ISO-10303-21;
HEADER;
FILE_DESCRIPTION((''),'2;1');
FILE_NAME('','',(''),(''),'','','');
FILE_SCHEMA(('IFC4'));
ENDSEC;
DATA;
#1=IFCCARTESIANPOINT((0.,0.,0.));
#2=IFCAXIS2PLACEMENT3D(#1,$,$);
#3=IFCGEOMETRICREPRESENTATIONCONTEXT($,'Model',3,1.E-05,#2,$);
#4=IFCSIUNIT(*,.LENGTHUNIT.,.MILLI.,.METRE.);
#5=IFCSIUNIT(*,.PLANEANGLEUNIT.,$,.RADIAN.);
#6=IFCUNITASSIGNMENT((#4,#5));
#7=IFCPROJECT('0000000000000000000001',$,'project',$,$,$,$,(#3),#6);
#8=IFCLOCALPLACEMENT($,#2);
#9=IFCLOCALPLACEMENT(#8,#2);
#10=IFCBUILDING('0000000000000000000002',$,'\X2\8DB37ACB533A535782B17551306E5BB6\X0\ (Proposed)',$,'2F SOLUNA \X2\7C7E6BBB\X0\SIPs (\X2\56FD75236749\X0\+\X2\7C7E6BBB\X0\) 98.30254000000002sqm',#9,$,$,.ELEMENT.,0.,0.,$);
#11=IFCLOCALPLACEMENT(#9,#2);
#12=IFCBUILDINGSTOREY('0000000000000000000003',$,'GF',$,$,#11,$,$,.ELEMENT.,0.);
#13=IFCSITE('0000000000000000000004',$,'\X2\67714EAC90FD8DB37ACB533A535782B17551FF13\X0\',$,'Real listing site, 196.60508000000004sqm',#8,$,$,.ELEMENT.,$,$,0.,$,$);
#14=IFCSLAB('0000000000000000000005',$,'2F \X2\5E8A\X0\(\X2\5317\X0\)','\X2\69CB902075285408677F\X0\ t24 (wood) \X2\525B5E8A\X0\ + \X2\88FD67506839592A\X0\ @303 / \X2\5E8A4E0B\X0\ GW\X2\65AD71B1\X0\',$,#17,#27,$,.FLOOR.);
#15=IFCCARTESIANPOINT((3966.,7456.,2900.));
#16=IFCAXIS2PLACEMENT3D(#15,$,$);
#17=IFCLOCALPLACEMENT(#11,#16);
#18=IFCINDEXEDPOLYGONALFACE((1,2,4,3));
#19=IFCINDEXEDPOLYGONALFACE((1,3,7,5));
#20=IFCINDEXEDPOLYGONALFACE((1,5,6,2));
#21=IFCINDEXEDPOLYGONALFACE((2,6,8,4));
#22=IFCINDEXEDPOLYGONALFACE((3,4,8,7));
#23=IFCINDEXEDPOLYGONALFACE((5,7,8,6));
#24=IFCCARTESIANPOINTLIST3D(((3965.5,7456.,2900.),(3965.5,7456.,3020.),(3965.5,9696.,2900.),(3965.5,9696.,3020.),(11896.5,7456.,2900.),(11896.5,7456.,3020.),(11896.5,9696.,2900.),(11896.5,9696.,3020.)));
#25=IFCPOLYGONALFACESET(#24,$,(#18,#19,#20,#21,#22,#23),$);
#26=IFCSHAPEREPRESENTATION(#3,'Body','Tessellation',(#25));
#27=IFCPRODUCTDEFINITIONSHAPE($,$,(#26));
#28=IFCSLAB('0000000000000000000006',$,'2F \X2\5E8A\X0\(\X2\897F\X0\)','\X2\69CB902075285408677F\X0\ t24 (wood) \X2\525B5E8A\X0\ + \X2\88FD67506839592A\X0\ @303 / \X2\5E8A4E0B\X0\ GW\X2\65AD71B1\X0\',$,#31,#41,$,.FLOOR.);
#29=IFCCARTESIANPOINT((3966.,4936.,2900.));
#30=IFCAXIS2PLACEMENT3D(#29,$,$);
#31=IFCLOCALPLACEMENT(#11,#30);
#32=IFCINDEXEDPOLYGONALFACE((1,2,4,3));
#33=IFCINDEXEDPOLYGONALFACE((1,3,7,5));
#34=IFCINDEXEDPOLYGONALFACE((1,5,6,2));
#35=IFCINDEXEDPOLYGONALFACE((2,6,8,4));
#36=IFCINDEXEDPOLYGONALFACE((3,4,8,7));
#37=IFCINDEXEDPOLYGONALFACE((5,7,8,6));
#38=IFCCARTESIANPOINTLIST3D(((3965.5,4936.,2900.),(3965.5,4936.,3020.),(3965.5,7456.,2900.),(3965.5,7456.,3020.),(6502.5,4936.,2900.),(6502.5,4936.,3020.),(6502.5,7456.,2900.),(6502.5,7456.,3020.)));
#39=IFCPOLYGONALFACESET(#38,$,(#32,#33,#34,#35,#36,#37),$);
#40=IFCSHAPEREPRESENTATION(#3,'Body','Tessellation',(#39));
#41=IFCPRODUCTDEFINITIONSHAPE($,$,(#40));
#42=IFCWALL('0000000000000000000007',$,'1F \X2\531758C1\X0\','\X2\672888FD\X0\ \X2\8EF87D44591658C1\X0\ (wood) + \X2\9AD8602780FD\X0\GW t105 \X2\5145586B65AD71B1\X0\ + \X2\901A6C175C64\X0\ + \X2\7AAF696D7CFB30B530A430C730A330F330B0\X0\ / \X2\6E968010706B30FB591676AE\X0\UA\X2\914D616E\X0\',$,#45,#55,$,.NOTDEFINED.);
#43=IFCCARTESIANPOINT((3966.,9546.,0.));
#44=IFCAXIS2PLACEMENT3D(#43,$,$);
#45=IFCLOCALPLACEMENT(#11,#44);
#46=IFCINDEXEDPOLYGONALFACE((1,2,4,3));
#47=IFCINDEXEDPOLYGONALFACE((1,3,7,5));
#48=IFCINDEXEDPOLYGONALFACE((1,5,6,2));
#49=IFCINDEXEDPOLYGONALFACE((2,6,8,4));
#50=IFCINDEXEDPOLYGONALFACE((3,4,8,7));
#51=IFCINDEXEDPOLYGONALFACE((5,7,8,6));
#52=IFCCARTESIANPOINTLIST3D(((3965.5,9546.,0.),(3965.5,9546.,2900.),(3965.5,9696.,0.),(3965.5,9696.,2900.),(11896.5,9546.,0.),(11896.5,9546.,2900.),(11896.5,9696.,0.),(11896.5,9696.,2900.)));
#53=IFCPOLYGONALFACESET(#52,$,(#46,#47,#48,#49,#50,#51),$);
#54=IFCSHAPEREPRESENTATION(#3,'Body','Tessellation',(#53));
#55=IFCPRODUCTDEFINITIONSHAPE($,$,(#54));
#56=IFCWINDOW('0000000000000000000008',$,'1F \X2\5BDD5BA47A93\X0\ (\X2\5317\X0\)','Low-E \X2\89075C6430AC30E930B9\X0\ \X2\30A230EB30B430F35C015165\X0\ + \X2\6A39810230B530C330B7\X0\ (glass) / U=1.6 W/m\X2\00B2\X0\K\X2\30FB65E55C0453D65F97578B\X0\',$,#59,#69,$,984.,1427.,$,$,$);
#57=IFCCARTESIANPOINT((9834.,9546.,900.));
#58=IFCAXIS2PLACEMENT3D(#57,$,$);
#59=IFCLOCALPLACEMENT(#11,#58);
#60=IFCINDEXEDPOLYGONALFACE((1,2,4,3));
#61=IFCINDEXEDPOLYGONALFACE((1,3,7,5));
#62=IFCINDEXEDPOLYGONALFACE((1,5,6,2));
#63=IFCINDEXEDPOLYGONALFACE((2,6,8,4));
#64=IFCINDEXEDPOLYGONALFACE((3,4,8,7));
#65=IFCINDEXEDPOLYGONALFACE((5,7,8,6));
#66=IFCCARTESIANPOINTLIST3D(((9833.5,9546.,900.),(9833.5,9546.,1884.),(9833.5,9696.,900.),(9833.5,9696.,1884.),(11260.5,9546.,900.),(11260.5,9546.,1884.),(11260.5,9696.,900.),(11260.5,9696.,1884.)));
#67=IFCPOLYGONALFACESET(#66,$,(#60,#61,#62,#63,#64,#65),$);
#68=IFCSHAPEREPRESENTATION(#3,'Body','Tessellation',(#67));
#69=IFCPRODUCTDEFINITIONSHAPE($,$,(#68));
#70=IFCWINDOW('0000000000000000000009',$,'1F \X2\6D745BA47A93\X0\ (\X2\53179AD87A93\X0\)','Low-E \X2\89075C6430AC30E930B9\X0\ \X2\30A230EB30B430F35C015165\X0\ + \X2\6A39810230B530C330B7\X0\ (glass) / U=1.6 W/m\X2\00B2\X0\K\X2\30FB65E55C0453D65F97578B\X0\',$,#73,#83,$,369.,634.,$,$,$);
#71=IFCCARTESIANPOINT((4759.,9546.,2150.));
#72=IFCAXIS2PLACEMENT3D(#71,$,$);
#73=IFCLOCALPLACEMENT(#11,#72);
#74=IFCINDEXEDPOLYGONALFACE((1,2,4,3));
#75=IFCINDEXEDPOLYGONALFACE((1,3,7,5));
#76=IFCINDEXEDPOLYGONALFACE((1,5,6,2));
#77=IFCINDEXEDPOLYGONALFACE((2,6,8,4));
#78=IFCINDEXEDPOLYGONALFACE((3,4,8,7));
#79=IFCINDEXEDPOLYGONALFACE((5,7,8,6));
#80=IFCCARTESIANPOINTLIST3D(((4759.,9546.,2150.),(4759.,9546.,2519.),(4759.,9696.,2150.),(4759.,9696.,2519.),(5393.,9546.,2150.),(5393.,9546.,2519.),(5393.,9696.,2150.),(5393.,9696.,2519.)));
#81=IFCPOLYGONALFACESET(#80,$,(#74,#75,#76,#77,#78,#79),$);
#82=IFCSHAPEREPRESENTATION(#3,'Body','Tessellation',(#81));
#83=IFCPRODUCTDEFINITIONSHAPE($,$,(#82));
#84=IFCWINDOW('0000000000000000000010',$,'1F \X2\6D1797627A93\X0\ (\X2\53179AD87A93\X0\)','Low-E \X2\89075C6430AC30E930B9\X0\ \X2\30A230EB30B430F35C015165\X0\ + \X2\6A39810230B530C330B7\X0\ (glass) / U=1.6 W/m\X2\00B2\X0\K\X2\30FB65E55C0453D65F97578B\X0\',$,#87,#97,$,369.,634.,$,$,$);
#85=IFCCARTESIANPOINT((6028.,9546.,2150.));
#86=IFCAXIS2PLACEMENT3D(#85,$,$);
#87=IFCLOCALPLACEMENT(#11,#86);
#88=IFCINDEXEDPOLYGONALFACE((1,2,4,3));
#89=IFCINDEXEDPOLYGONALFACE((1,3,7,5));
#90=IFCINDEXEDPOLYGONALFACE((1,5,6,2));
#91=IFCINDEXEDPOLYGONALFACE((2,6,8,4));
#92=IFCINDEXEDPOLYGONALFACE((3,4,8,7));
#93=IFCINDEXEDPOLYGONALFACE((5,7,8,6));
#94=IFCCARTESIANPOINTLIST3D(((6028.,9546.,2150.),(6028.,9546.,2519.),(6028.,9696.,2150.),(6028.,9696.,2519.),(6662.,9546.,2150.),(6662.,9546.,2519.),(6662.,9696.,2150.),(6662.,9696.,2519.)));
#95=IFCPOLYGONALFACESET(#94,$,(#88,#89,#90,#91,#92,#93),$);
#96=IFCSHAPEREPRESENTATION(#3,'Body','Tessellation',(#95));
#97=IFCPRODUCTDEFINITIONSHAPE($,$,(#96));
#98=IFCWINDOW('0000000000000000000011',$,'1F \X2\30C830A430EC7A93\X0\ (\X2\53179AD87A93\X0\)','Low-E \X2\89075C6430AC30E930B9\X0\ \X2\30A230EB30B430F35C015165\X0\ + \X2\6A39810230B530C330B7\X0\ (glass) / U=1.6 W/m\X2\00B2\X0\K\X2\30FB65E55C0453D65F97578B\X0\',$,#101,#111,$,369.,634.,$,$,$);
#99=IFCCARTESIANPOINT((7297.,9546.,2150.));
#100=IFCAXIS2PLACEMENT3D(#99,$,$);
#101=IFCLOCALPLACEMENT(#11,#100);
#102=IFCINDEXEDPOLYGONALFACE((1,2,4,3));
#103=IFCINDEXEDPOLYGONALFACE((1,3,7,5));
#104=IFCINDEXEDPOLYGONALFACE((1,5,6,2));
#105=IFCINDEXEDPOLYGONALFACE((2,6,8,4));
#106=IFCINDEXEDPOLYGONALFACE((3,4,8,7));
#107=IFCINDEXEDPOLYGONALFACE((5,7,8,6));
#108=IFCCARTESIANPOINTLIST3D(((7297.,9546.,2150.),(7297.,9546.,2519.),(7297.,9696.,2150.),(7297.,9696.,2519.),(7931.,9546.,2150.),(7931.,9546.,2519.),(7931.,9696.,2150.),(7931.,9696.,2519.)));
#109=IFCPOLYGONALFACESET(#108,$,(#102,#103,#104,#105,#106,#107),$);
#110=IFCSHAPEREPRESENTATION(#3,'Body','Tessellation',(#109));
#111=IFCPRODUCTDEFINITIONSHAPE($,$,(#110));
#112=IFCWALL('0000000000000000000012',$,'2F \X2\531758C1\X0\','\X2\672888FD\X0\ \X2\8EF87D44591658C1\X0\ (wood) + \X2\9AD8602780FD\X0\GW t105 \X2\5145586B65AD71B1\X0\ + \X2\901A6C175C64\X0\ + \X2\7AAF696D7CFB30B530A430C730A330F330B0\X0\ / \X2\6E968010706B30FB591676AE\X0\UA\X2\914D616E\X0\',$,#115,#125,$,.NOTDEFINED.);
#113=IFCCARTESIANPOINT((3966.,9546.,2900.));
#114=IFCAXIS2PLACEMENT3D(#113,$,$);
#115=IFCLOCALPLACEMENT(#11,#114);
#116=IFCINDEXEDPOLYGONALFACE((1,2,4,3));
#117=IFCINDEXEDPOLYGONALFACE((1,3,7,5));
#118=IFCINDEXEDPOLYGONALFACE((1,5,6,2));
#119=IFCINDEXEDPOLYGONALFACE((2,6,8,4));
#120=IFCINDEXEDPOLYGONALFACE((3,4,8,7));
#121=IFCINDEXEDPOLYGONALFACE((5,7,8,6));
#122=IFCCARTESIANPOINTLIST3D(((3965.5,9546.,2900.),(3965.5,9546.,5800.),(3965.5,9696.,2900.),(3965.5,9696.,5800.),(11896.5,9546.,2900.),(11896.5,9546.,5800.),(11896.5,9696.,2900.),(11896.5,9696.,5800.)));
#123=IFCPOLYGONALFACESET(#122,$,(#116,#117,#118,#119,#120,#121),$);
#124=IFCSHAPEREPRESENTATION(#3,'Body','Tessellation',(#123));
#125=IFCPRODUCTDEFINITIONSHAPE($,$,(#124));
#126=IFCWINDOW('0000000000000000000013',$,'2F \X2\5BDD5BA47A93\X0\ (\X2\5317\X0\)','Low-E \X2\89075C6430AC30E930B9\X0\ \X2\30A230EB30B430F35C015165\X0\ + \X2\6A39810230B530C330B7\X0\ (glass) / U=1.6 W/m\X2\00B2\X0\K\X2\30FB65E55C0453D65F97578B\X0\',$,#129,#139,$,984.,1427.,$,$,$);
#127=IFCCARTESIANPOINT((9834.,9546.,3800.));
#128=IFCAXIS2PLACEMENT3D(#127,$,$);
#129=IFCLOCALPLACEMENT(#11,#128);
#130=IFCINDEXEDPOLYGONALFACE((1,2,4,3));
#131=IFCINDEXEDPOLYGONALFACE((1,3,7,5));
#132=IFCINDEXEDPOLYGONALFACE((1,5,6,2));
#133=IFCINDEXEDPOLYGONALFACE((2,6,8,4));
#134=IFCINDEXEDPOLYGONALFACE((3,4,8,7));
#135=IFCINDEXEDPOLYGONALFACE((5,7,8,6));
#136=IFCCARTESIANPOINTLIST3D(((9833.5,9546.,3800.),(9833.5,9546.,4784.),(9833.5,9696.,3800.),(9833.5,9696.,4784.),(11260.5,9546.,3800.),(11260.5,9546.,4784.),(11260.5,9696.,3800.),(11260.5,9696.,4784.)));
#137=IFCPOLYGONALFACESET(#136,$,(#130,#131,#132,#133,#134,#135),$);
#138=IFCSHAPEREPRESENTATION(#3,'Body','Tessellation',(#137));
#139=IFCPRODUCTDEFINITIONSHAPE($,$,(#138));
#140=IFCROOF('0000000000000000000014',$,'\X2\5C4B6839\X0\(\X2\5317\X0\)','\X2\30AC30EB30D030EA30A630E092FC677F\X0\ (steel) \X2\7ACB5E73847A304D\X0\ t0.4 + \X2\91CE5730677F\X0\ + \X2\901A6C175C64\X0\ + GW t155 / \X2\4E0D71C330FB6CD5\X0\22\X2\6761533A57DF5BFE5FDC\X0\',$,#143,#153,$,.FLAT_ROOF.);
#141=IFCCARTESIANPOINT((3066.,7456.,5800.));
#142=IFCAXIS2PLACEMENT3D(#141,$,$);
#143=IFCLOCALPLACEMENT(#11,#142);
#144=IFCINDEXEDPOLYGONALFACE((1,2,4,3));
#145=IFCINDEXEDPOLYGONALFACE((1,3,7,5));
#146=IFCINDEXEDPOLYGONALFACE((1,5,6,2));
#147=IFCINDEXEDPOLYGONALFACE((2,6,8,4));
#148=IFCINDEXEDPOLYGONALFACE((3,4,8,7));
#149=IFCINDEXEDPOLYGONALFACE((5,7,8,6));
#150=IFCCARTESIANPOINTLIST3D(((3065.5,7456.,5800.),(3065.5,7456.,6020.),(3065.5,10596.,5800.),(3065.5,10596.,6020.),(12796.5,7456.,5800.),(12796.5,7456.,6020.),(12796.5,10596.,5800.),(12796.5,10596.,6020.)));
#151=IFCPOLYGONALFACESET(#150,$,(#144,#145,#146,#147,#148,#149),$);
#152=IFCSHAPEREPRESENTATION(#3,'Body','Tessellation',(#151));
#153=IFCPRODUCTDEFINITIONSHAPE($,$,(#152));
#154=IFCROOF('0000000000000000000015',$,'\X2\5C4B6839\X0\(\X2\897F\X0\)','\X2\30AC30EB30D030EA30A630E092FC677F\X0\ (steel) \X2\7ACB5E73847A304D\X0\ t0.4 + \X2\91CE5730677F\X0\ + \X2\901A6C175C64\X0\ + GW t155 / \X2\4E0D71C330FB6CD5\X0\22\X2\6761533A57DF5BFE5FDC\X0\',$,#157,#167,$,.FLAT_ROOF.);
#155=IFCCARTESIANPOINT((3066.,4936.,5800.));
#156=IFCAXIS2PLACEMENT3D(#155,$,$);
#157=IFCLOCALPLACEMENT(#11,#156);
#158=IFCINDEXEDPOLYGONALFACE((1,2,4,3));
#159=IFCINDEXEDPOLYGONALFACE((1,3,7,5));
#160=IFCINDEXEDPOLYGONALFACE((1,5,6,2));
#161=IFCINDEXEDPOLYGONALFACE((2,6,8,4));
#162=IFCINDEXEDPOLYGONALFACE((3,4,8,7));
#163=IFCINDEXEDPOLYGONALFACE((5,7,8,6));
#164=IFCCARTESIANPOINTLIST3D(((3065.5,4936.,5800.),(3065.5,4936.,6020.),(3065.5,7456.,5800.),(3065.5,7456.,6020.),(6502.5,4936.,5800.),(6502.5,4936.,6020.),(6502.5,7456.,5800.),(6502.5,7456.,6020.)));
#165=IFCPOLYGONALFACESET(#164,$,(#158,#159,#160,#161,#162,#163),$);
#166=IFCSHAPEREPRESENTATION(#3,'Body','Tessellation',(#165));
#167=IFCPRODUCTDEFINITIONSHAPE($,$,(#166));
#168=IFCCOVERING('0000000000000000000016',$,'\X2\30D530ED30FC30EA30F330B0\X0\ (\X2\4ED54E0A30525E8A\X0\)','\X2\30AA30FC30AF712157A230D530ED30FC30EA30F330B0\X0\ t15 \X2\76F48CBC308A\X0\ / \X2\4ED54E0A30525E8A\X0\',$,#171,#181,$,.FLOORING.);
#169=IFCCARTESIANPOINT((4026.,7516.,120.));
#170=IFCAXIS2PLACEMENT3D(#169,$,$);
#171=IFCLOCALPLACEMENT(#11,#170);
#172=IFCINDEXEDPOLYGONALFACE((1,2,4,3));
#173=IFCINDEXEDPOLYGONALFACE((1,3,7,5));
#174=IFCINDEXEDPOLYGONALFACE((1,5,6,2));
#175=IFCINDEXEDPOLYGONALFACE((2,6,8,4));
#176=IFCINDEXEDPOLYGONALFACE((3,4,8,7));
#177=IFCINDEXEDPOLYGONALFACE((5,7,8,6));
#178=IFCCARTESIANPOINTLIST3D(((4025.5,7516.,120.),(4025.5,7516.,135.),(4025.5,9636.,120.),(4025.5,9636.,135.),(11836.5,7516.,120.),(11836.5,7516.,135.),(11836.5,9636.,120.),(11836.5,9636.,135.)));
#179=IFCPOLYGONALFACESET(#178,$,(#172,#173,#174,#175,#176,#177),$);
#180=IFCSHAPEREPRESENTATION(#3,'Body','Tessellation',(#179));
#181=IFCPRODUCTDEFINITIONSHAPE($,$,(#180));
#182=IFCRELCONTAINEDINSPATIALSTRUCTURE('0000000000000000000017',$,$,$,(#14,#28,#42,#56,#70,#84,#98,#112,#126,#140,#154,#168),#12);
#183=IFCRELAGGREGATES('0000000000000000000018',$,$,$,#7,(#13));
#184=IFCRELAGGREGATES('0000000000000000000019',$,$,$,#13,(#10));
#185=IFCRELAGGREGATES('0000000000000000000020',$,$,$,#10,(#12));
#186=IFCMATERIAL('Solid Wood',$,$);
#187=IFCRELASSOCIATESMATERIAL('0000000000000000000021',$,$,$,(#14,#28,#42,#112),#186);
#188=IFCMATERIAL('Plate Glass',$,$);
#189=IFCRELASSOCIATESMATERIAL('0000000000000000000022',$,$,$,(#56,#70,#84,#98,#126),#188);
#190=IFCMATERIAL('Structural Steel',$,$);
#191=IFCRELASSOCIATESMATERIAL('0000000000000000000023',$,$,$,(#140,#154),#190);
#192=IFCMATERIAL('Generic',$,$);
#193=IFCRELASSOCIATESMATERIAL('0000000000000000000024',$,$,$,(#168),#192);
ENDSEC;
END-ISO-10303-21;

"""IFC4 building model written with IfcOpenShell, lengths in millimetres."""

from ifc_helpers import new_model, si_unit, frame, frame_2d, origin, place, context, project, spatial, rectangle, extrude, material, element, fill, save


model = new_model("IFC4")

# Units and contexts
model_context = context("Model", 3, precision=1e-05, world=origin())
ifc_project = project(units=[si_unit("LENGTHUNIT", "METRE", prefix="MILLI"), si_unit("PLANEANGLEUNIT", "RADIAN")], contexts=[model_context])

# Site, building, storey
site_placement = place(None, origin())
site = spatial("IfcSite", under=ifc_project, at=site_placement, Name="東京都足立区南花畑３", ObjectType="Real listing site, 196.60508000000004sqm", CompositionType="ELEMENT", RefElevation=0.0)
building_placement = place(site_placement, origin())
building = spatial("IfcBuilding", under=site, at=building_placement, Name="足立区南花畑の家 (Proposed)", ObjectType="2F SOLUNA 籾殻SIPs (国産杉+籾殻) 98.30254000000002sqm", CompositionType="ELEMENT", ElevationOfRefHeight=0.0, ElevationOfTerrain=0.0)
storey_placement = place(building_placement, origin())
storey = spatial("IfcBuildingStorey", under=building, at=storey_placement, Name="GF", CompositionType="ELEMENT", Elevation=0.0)

# Slabs
ifc_material_1 = material(Name="Solid Wood")
slab_1_placement = place(storey_placement, frame((3966.0, 7456.0, 2900.0)))
element("IfcSlab", 1, at=slab_1_placement, inside=storey, material=ifc_material_1, Name="2F 床(北)", Description="構造用合板 t24 (wood) 剛床 + 製材根太 @303 / 床下 GW断熱", PredefinedType="FLOOR", context=model_context, shape_type="SweptSolid", body=[
    extrude(rectangle(XDim=7931.0, YDim=2240.0, at=frame_2d((3965.0, 1120.0))), frame((3966.0, 7456.0, 2900.0)), (0.0, 0.0, 1.0), 120.0),
])
slab_2_placement = place(storey_placement, frame((3966.0, 4936.0, 2900.0)))
element("IfcSlab", 2, at=slab_2_placement, inside=storey, material=ifc_material_1, Name="2F 床(西)", Description="構造用合板 t24 (wood) 剛床 + 製材根太 @303 / 床下 GW断熱", PredefinedType="FLOOR", context=model_context, shape_type="SweptSolid", body=[
    extrude(rectangle(XDim=2537.0, YDim=2520.0, at=frame_2d((1268.0, 1260.0))), frame((3966.0, 4936.0, 2900.0)), (0.0, 0.0, 1.0), 120.0),
])

# Wall, openings, windows
wall_1_placement = place(storey_placement, frame((3966.0, 9546.0, 0.0)))
wall_1 = element("IfcWall", 3, at=wall_1_placement, inside=storey, material=ifc_material_1, Name="1F 北壁", Description="木製 軸組外壁 (wood) + 高性能GW t105 充填断熱 + 通気層 + 窯業系サイディング / 準耐火・外皮UA配慮", PredefinedType="NOTDEFINED", context=model_context, shape_type="SweptSolid", body=[
    extrude(rectangle(XDim=7931.0, YDim=150.0, at=frame_2d((3965.0, 75.0))), frame((3966.0, 9546.0, 0.0)), (0.0, 0.0, 1.0), 2900.0),
])
opening_1_placement = place(storey_placement, frame((9834.0, 9546.0, 900.0)))
opening_1 = element("IfcOpeningElement", 4, at=opening_1_placement, cuts=wall_1, PredefinedType="NOTDEFINED", context=model_context, shape_type="SweptSolid", body=[
    extrude(rectangle(XDim=1427.0, YDim=150.0, at=frame_2d((713.0, 75.0))), frame((9834.0, 9546.0, 900.0)), (0.0, 0.0, 1.0), 984.0),
])
opening_2_placement = place(storey_placement, frame((4759.0, 9546.0, 2150.0)))
opening_2 = element("IfcOpeningElement", 5, at=opening_2_placement, cuts=wall_1, PredefinedType="NOTDEFINED", context=model_context, shape_type="SweptSolid", body=[
    extrude(rectangle(XDim=634.0, YDim=150.0, at=frame_2d((317.0, 75.0))), frame((4759.0, 9546.0, 2150.0)), (0.0, 0.0, 1.0), 369.0),
])
opening_3_placement = place(storey_placement, frame((6028.0, 9546.0, 2150.0)))
opening_3 = element("IfcOpeningElement", 6, at=opening_3_placement, cuts=wall_1, PredefinedType="NOTDEFINED", context=model_context, shape_type="SweptSolid", body=[
    extrude(rectangle(XDim=634.0, YDim=150.0, at=frame_2d((317.0, 75.0))), frame((6028.0, 9546.0, 2150.0)), (0.0, 0.0, 1.0), 369.0),
])
opening_4_placement = place(storey_placement, frame((7297.0, 9546.0, 2150.0)))
opening_4 = element("IfcOpeningElement", 7, at=opening_4_placement, cuts=wall_1, PredefinedType="NOTDEFINED", context=model_context, shape_type="SweptSolid", body=[
    extrude(rectangle(XDim=634.0, YDim=150.0, at=frame_2d((317.0, 75.0))), frame((7297.0, 9546.0, 2150.0)), (0.0, 0.0, 1.0), 369.0),
])
ifc_material_2 = material(Name="Plate Glass")
window_1_placement = place(storey_placement, frame((9834.0, 9546.0, 900.0)))
window_1 = element("IfcWindow", 8, at=window_1_placement, inside=storey, material=ifc_material_2, Name="1F 寝室窓 (北)", Description="Low-E 複層ガラス アルゴン封入 + 樹脂サッシ (glass) / U=1.6 W/m²K・日射取得型", OverallHeight=984.0, OverallWidth=1427.0, context=model_context, shape_type="SweptSolid", body=[
    extrude(rectangle(XDim=1427.0, YDim=150.0, at=frame_2d((713.0, 75.0))), frame((9834.0, 9546.0, 900.0)), (0.0, 0.0, 1.0), 984.0),
])
fill(opening_1, window_1)
window_2_placement = place(storey_placement, frame((4759.0, 9546.0, 2150.0)))
window_2 = element("IfcWindow", 9, at=window_2_placement, inside=storey, material=ifc_material_2, Name="1F 浴室窓 (北高窓)", Description="Low-E 複層ガラス アルゴン封入 + 樹脂サッシ (glass) / U=1.6 W/m²K・日射取得型", OverallHeight=369.0, OverallWidth=634.0, context=model_context, shape_type="SweptSolid", body=[
    extrude(rectangle(XDim=634.0, YDim=150.0, at=frame_2d((317.0, 75.0))), frame((4759.0, 9546.0, 2150.0)), (0.0, 0.0, 1.0), 369.0),
])
fill(opening_2, window_2)
window_3_placement = place(storey_placement, frame((6028.0, 9546.0, 2150.0)))
window_3 = element("IfcWindow", 10, at=window_3_placement, inside=storey, material=ifc_material_2, Name="1F 洗面窓 (北高窓)", Description="Low-E 複層ガラス アルゴン封入 + 樹脂サッシ (glass) / U=1.6 W/m²K・日射取得型", OverallHeight=369.0, OverallWidth=634.0, context=model_context, shape_type="SweptSolid", body=[
    extrude(rectangle(XDim=634.0, YDim=150.0, at=frame_2d((317.0, 75.0))), frame((6028.0, 9546.0, 2150.0)), (0.0, 0.0, 1.0), 369.0),
])
fill(opening_3, window_3)
window_4_placement = place(storey_placement, frame((7297.0, 9546.0, 2150.0)))
window_4 = element("IfcWindow", 11, at=window_4_placement, inside=storey, material=ifc_material_2, Name="1F トイレ窓 (北高窓)", Description="Low-E 複層ガラス アルゴン封入 + 樹脂サッシ (glass) / U=1.6 W/m²K・日射取得型", OverallHeight=369.0, OverallWidth=634.0, context=model_context, shape_type="SweptSolid", body=[
    extrude(rectangle(XDim=634.0, YDim=150.0, at=frame_2d((317.0, 75.0))), frame((7297.0, 9546.0, 2150.0)), (0.0, 0.0, 1.0), 369.0),
])
fill(opening_4, window_4)

# Wall, opening, window
wall_2_placement = place(storey_placement, frame((3966.0, 9546.0, 2900.0)))
wall_2 = element("IfcWall", 12, at=wall_2_placement, inside=storey, material=ifc_material_1, Name="2F 北壁", Description="木製 軸組外壁 (wood) + 高性能GW t105 充填断熱 + 通気層 + 窯業系サイディング / 準耐火・外皮UA配慮", PredefinedType="NOTDEFINED", context=model_context, shape_type="SweptSolid", body=[
    extrude(rectangle(XDim=7931.0, YDim=150.0, at=frame_2d((3965.0, 75.0))), frame((3966.0, 9546.0, 2900.0)), (0.0, 0.0, 1.0), 2900.0),
])
opening_5_placement = place(storey_placement, frame((9834.0, 9546.0, 3800.0)))
opening_5 = element("IfcOpeningElement", 13, at=opening_5_placement, cuts=wall_2, PredefinedType="NOTDEFINED", context=model_context, shape_type="SweptSolid", body=[
    extrude(rectangle(XDim=1427.0, YDim=150.0, at=frame_2d((713.0, 75.0))), frame((9834.0, 9546.0, 3800.0)), (0.0, 0.0, 1.0), 984.0),
])
window_5_placement = place(storey_placement, frame((9834.0, 9546.0, 3800.0)))
window_5 = element("IfcWindow", 14, at=window_5_placement, inside=storey, material=ifc_material_2, Name="2F 寝室窓 (北)", Description="Low-E 複層ガラス アルゴン封入 + 樹脂サッシ (glass) / U=1.6 W/m²K・日射取得型", OverallHeight=984.0, OverallWidth=1427.0, context=model_context, shape_type="SweptSolid", body=[
    extrude(rectangle(XDim=1427.0, YDim=150.0, at=frame_2d((713.0, 75.0))), frame((9834.0, 9546.0, 3800.0)), (0.0, 0.0, 1.0), 984.0),
])
fill(opening_5, window_5)

# Roofs
ifc_material_3 = material(Name="Structural Steel")
for number, where, name in (
    (15, (3066.0, 7456.0, 5800.0), "屋根(北)"),
):
    element("IfcRoof", number, at=place(storey_placement, frame(where)), inside=storey, material=ifc_material_3, Name=name, Description="ガルバリウム鋼板 (steel) 立平葺き t0.4 + 野地板 + 通気層 + GW t155 / 不燃・法22条区域対応", PredefinedType="FLAT_ROOF", context=model_context, shape_type="SweptSolid", body=[
        extrude(rectangle(XDim=9731.0, YDim=3140.0, at=frame_2d((4865.0, 1570.0))), frame((3066.0, 7456.0, 5800.0)), (0.0, 0.0, 1.0), 220.0),
    ])
roof_placement = place(storey_placement, frame((3066.0, 4936.0, 5800.0)))
element("IfcRoof", 16, at=roof_placement, inside=storey, material=ifc_material_3, Name="屋根(西)", Description="ガルバリウム鋼板 (steel) 立平葺き t0.4 + 野地板 + 通気層 + GW t155 / 不燃・法22条区域対応", PredefinedType="FLAT_ROOF", context=model_context, shape_type="SweptSolid", body=[
    extrude(rectangle(XDim=3437.0, YDim=2520.0, at=frame_2d((1718.0, 1260.0))), frame((3066.0, 4936.0, 5800.0)), (0.0, 0.0, 1.0), 220.0),
])

# Covering
ifc_material_4 = material(Name="Generic")
covering_1_placement = place(storey_placement, frame((4026.0, 7516.0, 120.0)))
element("IfcCovering", 17, at=covering_1_placement, inside=storey, material=ifc_material_4, Name="フローリング (仕上げ床)", Description="オーク無垢フローリング t15 直貼り / 仕上げ床", PredefinedType="FLOORING", context=model_context, shape_type="SweptSolid", body=[
    extrude(rectangle(XDim=7811.0, YDim=2120.0, at=frame_2d((3905.0, 1060.0))), frame((4026.0, 7516.0, 120.0)), (0.0, 0.0, 1.0), 15.0),
])

save(model, "model.ifc")
